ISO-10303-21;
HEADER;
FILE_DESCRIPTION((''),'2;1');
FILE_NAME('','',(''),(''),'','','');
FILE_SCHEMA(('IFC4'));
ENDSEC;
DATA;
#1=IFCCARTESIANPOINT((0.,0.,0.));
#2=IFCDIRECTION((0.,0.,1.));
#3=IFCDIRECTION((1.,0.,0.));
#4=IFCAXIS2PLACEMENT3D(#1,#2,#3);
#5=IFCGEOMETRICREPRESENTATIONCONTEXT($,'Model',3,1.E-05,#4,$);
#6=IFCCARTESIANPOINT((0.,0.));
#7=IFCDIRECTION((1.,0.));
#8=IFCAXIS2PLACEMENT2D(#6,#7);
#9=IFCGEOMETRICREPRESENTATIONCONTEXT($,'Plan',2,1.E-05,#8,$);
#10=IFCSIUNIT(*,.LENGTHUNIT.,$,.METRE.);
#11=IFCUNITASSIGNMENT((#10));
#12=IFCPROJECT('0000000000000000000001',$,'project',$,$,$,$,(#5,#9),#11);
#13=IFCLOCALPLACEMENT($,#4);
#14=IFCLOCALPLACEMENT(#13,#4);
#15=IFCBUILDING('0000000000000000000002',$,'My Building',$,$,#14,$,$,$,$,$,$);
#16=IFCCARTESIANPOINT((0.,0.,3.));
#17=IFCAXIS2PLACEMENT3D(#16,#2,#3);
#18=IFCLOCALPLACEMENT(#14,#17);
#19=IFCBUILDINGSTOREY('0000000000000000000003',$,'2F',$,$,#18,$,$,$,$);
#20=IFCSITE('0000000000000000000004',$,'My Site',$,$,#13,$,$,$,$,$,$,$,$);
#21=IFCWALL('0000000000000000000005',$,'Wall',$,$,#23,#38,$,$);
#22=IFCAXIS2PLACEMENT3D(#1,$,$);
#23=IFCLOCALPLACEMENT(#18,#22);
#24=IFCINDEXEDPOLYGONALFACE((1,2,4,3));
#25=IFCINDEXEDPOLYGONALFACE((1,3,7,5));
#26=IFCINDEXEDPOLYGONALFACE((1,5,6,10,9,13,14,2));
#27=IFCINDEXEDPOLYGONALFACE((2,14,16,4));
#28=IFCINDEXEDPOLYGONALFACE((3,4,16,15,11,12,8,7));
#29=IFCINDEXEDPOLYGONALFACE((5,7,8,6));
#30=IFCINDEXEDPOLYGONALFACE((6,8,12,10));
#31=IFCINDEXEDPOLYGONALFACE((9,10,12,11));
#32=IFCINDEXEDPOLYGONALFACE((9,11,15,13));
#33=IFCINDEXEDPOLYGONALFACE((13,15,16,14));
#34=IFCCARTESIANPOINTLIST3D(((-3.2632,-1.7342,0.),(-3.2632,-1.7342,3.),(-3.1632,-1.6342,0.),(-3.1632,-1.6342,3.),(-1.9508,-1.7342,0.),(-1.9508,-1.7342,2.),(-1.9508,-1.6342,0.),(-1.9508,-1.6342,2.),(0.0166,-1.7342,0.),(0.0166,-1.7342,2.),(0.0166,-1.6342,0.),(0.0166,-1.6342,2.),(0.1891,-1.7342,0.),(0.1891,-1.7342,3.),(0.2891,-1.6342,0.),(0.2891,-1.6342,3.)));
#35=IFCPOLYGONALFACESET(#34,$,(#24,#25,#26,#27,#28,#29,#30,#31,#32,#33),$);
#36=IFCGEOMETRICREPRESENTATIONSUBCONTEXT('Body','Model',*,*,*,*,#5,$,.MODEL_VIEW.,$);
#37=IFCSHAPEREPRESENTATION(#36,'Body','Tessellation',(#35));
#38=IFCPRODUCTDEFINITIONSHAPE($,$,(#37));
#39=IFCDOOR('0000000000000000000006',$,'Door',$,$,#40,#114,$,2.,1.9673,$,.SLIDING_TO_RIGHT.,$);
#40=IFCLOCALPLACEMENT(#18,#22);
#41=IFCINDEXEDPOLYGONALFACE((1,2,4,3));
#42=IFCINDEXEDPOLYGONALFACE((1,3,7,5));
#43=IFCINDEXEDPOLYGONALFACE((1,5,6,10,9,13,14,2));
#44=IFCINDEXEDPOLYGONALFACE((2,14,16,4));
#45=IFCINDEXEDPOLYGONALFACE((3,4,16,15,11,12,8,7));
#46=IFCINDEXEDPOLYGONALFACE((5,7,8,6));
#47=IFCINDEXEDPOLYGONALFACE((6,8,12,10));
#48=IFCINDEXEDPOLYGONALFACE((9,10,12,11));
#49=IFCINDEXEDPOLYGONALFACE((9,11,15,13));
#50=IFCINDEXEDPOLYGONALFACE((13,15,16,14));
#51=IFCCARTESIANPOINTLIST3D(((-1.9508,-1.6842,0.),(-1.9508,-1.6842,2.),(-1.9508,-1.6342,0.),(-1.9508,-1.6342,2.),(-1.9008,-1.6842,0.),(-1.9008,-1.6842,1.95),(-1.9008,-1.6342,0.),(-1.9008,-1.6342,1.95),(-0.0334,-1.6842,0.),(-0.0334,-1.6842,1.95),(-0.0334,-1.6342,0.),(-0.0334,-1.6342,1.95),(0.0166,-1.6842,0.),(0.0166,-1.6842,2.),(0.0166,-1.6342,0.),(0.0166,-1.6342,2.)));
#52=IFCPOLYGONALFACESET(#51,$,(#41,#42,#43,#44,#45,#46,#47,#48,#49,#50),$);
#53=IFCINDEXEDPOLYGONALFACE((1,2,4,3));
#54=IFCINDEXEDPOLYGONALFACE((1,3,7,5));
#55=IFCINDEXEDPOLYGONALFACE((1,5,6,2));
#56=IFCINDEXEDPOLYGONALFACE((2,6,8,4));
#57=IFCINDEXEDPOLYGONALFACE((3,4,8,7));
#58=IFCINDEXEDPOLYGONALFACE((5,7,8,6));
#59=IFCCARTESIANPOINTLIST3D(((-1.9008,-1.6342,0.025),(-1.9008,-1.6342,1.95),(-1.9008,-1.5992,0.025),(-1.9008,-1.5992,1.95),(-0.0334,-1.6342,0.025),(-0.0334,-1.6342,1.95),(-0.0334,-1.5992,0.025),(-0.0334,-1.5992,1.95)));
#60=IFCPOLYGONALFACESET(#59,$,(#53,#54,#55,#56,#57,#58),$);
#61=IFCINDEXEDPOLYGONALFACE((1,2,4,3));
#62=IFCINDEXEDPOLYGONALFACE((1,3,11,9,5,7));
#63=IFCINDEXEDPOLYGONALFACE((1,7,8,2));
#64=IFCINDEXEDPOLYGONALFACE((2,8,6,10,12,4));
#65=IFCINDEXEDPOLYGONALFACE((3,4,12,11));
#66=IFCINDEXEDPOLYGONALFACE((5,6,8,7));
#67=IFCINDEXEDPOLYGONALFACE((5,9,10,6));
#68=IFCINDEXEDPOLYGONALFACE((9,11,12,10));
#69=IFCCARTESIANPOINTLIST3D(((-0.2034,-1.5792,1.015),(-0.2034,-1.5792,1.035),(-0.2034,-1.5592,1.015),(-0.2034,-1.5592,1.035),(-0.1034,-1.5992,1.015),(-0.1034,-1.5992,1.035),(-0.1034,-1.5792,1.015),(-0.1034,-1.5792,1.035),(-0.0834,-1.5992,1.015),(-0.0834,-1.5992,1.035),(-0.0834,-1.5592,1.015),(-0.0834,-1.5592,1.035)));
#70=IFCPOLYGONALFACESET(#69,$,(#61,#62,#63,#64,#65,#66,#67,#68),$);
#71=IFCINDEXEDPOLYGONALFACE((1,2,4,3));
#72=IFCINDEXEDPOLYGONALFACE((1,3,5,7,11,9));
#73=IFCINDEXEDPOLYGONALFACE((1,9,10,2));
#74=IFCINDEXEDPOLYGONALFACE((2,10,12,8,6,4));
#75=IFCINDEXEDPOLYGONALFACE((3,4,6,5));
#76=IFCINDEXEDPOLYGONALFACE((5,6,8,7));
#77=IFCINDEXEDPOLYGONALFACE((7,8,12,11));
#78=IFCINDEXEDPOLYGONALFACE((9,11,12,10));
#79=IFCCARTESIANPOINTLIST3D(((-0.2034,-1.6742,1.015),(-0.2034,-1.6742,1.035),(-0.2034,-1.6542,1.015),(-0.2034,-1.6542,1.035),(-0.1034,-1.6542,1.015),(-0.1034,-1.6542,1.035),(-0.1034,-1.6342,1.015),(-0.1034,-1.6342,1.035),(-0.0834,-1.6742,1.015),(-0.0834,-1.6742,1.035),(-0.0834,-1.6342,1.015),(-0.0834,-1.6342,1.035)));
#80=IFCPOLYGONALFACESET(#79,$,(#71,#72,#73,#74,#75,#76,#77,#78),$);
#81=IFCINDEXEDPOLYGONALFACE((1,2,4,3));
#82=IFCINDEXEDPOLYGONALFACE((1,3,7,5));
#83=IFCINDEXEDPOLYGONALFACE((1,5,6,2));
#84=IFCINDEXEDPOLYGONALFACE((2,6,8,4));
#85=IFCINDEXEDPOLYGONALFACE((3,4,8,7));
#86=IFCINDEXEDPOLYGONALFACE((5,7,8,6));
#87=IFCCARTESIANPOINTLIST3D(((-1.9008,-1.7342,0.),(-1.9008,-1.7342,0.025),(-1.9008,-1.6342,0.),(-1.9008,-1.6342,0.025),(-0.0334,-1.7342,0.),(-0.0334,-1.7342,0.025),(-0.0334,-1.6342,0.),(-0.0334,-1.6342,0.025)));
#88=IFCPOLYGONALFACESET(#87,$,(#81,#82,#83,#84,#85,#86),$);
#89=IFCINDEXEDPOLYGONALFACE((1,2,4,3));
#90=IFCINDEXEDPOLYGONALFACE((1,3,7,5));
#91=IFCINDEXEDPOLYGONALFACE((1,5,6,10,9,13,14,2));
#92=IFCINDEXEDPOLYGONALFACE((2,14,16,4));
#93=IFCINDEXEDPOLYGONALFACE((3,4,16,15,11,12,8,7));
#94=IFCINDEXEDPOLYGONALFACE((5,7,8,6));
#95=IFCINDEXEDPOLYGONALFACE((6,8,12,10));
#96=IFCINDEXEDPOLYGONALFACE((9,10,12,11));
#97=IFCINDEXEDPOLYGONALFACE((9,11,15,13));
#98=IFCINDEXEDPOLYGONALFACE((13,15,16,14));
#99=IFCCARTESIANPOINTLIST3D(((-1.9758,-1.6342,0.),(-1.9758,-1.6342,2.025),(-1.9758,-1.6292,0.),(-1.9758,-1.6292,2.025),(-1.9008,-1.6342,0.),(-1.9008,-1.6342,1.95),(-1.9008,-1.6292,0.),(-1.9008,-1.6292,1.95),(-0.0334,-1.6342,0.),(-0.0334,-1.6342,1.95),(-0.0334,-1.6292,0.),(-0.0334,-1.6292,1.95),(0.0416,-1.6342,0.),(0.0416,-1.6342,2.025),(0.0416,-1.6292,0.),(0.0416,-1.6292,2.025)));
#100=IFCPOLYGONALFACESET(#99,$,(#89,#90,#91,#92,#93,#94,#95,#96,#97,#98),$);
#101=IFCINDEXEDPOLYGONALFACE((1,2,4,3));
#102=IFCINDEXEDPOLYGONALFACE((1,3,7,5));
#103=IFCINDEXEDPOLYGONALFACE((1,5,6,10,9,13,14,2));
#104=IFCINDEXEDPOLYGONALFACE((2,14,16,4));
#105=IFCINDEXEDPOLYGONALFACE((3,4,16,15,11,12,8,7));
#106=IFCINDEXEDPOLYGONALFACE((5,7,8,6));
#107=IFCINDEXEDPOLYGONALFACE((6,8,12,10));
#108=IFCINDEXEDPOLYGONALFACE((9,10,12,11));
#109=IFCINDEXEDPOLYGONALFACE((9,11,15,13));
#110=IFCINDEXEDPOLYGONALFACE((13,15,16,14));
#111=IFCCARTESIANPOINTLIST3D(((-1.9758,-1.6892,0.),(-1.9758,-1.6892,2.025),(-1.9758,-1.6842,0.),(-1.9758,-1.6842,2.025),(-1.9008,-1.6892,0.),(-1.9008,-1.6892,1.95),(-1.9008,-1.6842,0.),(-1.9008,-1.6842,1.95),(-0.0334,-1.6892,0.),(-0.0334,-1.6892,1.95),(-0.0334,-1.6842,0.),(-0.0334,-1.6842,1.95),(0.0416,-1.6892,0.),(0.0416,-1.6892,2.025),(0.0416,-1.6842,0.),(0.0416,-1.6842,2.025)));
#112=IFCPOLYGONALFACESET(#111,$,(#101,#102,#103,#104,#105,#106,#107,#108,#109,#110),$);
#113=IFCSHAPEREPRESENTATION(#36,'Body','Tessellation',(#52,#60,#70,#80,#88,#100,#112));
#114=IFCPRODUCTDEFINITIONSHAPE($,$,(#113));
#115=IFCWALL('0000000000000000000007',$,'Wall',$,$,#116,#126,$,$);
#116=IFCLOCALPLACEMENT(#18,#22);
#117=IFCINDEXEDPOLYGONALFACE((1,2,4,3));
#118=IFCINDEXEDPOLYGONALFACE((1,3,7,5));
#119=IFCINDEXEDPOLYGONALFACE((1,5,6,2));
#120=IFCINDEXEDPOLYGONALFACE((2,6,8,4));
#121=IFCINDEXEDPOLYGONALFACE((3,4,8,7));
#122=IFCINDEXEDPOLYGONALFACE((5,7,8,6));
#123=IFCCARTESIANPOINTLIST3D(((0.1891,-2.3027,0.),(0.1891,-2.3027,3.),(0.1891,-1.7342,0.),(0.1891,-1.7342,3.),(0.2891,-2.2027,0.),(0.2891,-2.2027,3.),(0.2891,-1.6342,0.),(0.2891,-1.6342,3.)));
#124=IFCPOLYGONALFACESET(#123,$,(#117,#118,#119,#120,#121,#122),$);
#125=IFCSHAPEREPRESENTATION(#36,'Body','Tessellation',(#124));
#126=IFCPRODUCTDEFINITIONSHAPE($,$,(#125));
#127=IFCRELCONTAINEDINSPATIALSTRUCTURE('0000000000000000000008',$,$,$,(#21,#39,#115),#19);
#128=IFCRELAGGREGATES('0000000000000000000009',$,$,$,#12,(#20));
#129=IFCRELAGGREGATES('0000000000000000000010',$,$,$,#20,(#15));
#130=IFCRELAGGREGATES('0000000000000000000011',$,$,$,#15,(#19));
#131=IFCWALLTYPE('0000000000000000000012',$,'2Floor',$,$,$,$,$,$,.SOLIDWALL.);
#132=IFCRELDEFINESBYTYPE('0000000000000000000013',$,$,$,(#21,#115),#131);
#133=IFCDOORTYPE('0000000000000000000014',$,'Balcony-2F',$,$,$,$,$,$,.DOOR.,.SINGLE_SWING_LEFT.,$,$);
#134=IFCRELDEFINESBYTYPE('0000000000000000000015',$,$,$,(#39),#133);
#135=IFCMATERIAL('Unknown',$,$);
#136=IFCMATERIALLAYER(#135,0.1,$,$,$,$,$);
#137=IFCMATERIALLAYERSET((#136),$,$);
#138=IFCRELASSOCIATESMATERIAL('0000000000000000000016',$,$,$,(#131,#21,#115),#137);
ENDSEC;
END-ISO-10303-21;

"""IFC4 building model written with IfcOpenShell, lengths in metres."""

from ifc_helpers import new_model, entity, si_unit, frame, origin_with_axes, origin_2d_with_axis, place, context, subcontext, project, spatial, line, indexed_curve, outline, extrude, shape, source, transform, mapped, material, layer, layer_set, layer_usage, type_object, type_shapes, element, fill, save


model = new_model("IFC4")

# Units and contexts
model_context = context("Model", 3, precision=1e-05, world=origin_with_axes())
plan_context = context("Plan", 2, precision=1e-05, world=origin_2d_with_axis())
body_context_1 = subcontext(model_context, "Body", "Model", "MODEL_VIEW")
body_context_2 = subcontext(plan_context, "Body", "Plan", "PLAN_VIEW")
ifc_project = project(units=[si_unit("LENGTHUNIT", "METRE")], contexts=[model_context, plan_context])

# Site, building, storey
site_placement = place(None, origin_with_axes())
site = spatial("IfcSite", under=ifc_project, at=site_placement, Name="My Site")
building_placement = place(site_placement, origin_with_axes())
building = spatial("IfcBuilding", under=site, at=building_placement, Name="My Building")
storey_placement = place(building_placement, frame((0.0, 0.0, 3.0), z_axis=(0.0, 0.0, 1.0), x_axis=(1.0, 0.0, 0.0)))
storey = spatial("IfcBuildingStorey", under=building, at=storey_placement, Name="2F")

# Shared definitions
ifc_material = material(Name="Unknown")

# Shared definitions
ifc_layer_1 = layer(ifc_material, 0.1)
ifc_layer_set_1 = layer_set([ifc_layer_1])
wall_type = type_object("IfcWallType", Name="2Floor", PredefinedType="SOLIDWALL", material=ifc_layer_set_1)

# Wall, opening, door
ifc_layer_usage_1 = layer_usage(ifc_layer_set_1, "AXIS2", "POSITIVE", 0.0)
wall_1_placement = place(storey_placement, frame((-3.2632, -1.7342, 0.0), z_axis=(0.0, 0.0, 1.0), x_axis=(1.0, 0.0, 0.0)))
wall_1 = element("IfcWall", 1, at=wall_1_placement, inside=storey, type_object=wall_type, material=ifc_layer_usage_1, Name="Wall", context=body_context_1, shape_type="SweptSolid", body=[
    extrude(outline(indexed_curve([(0.0, 0.0), (0.1, 0.1), (3.5523, 0.1), (3.4523, 0.0)], segments=[line(1, 2, 3, 4, 1)])), origin_with_axes(), (0.0, 0.0, 1.0), 3.0),
])
shared_shape_1 = source(origin_with_axes(), body_context_1, "Body", "SweptSolid", [
    extrude(outline(indexed_curve([(0.0, 0.0), (1.9673, 0.0), (1.9673, 2.0), (0.0, 2.0)], segments=[line(1, 2, 3, 4, 1)])), frame((0.0, -0.6, 0.0), z_axis=(0.0, -1.0, 0.0), x_axis=(1.0, 0.0, 0.0)), (0.0, 0.0, -1.0), 1.2),
])
opening_1_placement = place(wall_1_placement, frame((3.2797, 0.1, 0.0), z_axis=(0.0, 0.0, 1.0), x_axis=(-1.0, 0.0, 0.0)))
opening_1 = element("IfcOpeningElement", 2, at=opening_1_placement, cuts=wall_1, PredefinedType="OPENING", context=body_context_1, shape_type="MappedRepresentation", body=[
    mapped(shared_shape_1, transform((0.0, 0.0, 0.0), x_axis=(1.0, 0.0, 0.0), y_axis=(0.0, 1.0, 0.0), z_axis=(0.0, 0.0, 1.0), scale=1.0)),
])
door_type_1 = type_object("IfcDoorType", Name="Balcony-2F", OperationType="SINGLE_SWING_LEFT", PredefinedType="DOOR")
shared_shape_2 = source(origin_with_axes(), body_context_1, "Body", "SweptSolid", [
    extrude(outline(indexed_curve([(0.0, 0.0), (0.0, 2.0), (1.9673, 2.0), (1.9673, 0.0), (1.9173, 0.0), (1.9173, 1.95), (0.05, 1.95), (0.05, 0.0)], segments=[line(1, 2, 3, 4, 5, 6, 7, 8, 1)])), frame((0.0, 0.0, 0.0), z_axis=(0.0, -1.0, 0.0), x_axis=(1.0, 0.0, 0.0)), (0.0, 0.0, -1.0), 0.05),
    extrude(outline(indexed_curve([(0.0, 0.0), (1.8673, 0.0), (1.8673, 0.035), (0.0, 0.035)], segments=[line(1, 2, 3, 4, 1)])), frame((0.05, -0.035, 0.025), z_axis=(0.0, 0.0, 1.0), x_axis=(1.0, 0.0, 0.0)), (0.0, 0.0, 1.0), 1.925),
    extrude(outline(indexed_curve([(0.0, 0.0), (0.0, -0.04), (0.12, -0.04), (0.12, -0.02), (0.02, -0.02), (0.02, 0.0)], segments=[line(1, 2, 3, 4, 5, 6, 1)])), frame((0.1, -0.035, 1.015), z_axis=(0.0, 0.0, 1.0), x_axis=(1.0, 0.0, 0.0)), (0.0, 0.0, 1.0), 0.02),
    extrude(outline(indexed_curve([(0.0, 0.0), (0.0, 0.04), (0.12, 0.04), (0.12, 0.02), (0.02, 0.02), (0.02, 0.0)], segments=[line(1, 2, 3, 4, 5, 6, 1)])), frame((0.1, 0.0, 1.015), z_axis=(0.0, 0.0, 1.0), x_axis=(1.0, 0.0, 0.0)), (0.0, 0.0, 1.0), 0.02),
    extrude(outline(indexed_curve([(0.0, 0.0), (1.8673, 0.0), (1.8673, 0.1), (0.0, 0.1)], segments=[line(1, 2, 3, 4, 1)])), frame((0.05, 0.0, 0.0), z_axis=(0.0, 0.0, 1.0), x_axis=(1.0, 0.0, 0.0)), (0.0, 0.0, 1.0), 0.025),
    extrude(outline(indexed_curve([(0.0, 0.0), (0.0, 2.025), (2.0173, 2.025), (2.0173, 0.0), (1.9423, 0.0), (1.9423, 1.95), (0.075, 1.95), (0.075, 0.0)], segments=[line(1, 2, 3, 4, 5, 6, 7, 8, 1)])), frame((-0.025, -0.005, 0.0), z_axis=(0.0, -1.0, 0.0), x_axis=(1.0, 0.0, 0.0)), (0.0, 0.0, -1.0), 0.005),
    extrude(outline(indexed_curve([(0.0, 0.0), (0.0, 2.025), (2.0173, 2.025), (2.0173, 0.0), (1.9423, 0.0), (1.9423, 1.95), (0.075, 1.95), (0.075, 0.0)], segments=[line(1, 2, 3, 4, 5, 6, 7, 8, 1)])), frame((-0.025, 0.05, 0.0), z_axis=(0.0, -1.0, 0.0), x_axis=(1.0, 0.0, 0.0)), (0.0, 0.0, -1.0), 0.005),
])
shared_shape_3 = source(origin_with_axes(), body_context_2, "Body", "Curve2D", [
    entity("IfcIndexedPolyCurve", entity("IfcCartesianPointList2D", [[0.0, 0.0], [0.05, 0.0], [0.05, 0.05], [0.0, 0.05]]), [entity("IfcLineIndex", [1, 2, 3, 4, 1])]),
    entity("IfcIndexedPolyCurve", entity("IfcCartesianPointList2D", [[1.9673, 0.0], [1.9173, 0.0], [1.9173, 0.05], [1.9673, 0.05]]), [entity("IfcLineIndex", [1, 2, 3, 4, 1])]),
    entity("IfcIndexedPolyCurve", entity("IfcCartesianPointList2D", [[2.851, -0.035], [0.9837, -0.035], [0.9837, 0.0], [2.851, 0.0]]), [entity("IfcLineIndex", [1, 2, 3, 4, 1])]),
])
type_shapes(door_type_1, [shared_shape_2, shared_shape_3])
door_1_placement = place(opening_1_placement, frame((0.0, 0.0, 0.0), z_axis=(0.0, 0.0, 1.0), x_axis=(1.0, 0.0, 0.0)))
door_1 = element("IfcDoor", 3, at=door_1_placement, inside=storey, type_object=door_type_1, Name="Door", OperationType="SLIDING_TO_RIGHT", OverallHeight=2.0, OverallWidth=1.9673, shapes=[
    shape(body_context_1, "Body", "MappedRepresentation", [mapped(shared_shape_2, transform((0.0, 0.0, 0.0), x_axis=(1.0, 0.0, 0.0), y_axis=(0.0, 1.0, 0.0), z_axis=(0.0, 0.0, 1.0), scale=1.0))]),
    shape(body_context_2, "Body", "MappedRepresentation", [mapped(shared_shape_3, transform((0.0, 0.0, 0.0), x_axis=(1.0, 0.0, 0.0), y_axis=(0.0, 1.0, 0.0), z_axis=(0.0, 0.0, 1.0), scale=1.0))]),
])
fill(opening_1, door_1)

# Wall
ifc_layer_usage_2 = layer_usage(ifc_layer_set_1, "AXIS2", "POSITIVE", 0.0)
wall_2_placement = place(storey_placement, frame((0.1891, -1.7342, 0.0), z_axis=(0.0, 0.0, 1.0), x_axis=(0.0, -1.0, 0.0)))
element("IfcWall", 4, at=wall_2_placement, inside=storey, type_object=wall_type, material=ifc_layer_usage_2, Name="Wall", context=body_context_1, shape_type="SweptSolid", body=[
    extrude(outline(indexed_curve([(0.0, 0.0), (-0.1, 0.1), (0.4685, 0.1), (0.5685, 0.0)], segments=[line(1, 2, 3, 4, 1)])), origin_with_axes(), (0.0, 0.0, 1.0), 3.0),
])

save(model, "model.ifc")
